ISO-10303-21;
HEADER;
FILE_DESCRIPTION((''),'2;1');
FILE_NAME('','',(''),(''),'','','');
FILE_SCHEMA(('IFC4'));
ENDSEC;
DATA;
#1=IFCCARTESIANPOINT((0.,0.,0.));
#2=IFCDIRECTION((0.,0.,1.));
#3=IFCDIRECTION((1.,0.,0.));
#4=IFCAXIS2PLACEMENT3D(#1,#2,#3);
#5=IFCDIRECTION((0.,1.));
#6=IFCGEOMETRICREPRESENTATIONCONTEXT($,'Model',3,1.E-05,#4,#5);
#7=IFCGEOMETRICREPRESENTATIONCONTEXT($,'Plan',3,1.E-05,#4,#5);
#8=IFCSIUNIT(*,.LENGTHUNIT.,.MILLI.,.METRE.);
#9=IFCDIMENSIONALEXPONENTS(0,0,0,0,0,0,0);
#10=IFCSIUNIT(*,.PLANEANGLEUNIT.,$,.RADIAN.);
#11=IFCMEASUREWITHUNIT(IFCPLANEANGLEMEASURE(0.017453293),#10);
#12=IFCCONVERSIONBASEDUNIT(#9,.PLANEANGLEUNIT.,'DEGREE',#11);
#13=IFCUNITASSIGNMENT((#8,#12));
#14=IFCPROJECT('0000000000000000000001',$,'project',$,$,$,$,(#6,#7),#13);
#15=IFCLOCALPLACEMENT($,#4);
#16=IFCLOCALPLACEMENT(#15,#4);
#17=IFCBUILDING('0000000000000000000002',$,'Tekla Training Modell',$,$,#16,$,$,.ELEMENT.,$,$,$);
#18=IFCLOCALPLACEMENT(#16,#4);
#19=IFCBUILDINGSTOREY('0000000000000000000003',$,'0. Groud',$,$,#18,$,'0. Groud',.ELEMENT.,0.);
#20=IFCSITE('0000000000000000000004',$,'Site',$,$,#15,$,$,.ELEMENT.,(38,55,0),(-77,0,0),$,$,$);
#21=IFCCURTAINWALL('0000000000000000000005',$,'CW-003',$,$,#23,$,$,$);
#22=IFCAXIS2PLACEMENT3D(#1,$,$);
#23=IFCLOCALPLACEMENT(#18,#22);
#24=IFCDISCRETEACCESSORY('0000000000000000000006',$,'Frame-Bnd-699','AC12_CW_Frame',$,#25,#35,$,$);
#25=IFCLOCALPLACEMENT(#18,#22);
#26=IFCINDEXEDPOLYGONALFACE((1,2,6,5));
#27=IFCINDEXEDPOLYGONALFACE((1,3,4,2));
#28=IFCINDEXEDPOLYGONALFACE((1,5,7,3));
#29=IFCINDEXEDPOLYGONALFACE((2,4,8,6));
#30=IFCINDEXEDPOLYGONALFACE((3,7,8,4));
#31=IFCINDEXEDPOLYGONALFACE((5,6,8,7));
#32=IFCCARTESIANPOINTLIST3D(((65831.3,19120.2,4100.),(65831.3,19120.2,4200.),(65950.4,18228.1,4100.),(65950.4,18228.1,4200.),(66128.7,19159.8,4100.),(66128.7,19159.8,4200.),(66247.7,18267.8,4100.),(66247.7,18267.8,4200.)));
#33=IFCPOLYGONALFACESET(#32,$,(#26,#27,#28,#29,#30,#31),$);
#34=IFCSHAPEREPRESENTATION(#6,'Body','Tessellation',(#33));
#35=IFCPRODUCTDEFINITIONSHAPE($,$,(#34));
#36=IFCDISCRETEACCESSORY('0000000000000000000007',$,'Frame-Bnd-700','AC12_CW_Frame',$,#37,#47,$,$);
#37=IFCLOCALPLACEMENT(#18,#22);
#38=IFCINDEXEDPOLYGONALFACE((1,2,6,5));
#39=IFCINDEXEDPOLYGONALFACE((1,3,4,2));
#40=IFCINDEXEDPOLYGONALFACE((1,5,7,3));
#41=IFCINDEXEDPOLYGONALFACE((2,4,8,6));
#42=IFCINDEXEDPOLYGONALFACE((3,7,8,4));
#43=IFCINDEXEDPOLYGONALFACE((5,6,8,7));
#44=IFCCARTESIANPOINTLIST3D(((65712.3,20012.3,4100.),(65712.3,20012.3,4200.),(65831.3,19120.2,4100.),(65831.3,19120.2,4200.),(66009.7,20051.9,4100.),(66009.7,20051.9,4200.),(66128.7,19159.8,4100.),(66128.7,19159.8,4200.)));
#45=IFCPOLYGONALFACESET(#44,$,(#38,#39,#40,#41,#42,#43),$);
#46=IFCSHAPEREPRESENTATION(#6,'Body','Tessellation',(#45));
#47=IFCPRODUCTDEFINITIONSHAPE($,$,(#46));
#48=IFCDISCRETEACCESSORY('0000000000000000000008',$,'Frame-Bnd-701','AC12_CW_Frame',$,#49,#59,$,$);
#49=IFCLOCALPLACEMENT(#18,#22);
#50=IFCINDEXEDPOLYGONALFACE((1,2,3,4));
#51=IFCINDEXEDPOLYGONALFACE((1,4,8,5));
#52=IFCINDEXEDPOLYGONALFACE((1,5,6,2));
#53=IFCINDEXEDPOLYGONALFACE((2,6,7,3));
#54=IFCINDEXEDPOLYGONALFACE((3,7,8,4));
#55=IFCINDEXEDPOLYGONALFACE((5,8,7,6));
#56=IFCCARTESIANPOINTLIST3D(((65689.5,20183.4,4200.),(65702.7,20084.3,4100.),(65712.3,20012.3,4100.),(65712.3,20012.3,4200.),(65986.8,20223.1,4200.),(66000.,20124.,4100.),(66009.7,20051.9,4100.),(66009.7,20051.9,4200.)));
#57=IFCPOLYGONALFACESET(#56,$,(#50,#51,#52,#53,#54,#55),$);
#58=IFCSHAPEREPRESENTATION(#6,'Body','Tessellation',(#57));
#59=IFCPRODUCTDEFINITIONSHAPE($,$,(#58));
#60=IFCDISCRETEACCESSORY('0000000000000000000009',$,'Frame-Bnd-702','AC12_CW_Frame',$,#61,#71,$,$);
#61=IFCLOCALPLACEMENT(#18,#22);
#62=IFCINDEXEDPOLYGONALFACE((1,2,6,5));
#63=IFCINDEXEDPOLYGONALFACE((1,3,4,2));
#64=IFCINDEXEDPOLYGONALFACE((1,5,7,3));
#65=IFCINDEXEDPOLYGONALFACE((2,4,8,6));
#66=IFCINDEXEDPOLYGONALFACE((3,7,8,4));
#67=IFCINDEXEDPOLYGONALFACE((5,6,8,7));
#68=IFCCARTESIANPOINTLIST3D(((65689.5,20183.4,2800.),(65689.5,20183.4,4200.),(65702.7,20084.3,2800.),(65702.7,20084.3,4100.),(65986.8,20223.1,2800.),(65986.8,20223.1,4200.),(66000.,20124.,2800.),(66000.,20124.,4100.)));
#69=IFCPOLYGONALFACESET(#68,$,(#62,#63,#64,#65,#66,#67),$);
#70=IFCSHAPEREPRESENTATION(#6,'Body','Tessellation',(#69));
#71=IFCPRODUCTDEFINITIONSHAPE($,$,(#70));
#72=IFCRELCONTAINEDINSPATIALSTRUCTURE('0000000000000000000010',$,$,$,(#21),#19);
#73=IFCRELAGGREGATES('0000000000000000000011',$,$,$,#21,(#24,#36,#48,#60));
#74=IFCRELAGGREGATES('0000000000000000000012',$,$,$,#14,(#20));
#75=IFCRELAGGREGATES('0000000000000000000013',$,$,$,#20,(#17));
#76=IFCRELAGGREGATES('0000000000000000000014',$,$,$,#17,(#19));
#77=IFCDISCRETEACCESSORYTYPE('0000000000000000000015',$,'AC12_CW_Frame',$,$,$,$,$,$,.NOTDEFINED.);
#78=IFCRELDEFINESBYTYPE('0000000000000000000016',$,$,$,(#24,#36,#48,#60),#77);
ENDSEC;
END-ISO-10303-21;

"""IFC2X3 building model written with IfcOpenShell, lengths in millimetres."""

from ifc_helpers import new_model, entity, si_unit, converted_unit, direction, frame, origin_with_axes, place, context, project, spatial, polyline, outline, extrude, source, transform, mapped, type_object, element, aggregate, save


model = new_model("IFC2X3")

# Units and contexts
model_context = context("Model", 3, precision=1e-05, world=origin_with_axes(), true_north=direction((0.0, 1.0)))
plan_context = context("Plan", 3, precision=1e-05, world=origin_with_axes(), true_north=direction((0.0, 1.0)))
ifc_project = project(units=[si_unit("LENGTHUNIT", "METRE", prefix="MILLI"), converted_unit("PLANEANGLEUNIT", "DEGREE", entity("IfcPlaneAngleMeasure", 0.017453293), si_unit("PLANEANGLEUNIT", "RADIAN"), dimensions=[0, 0, 0, 0, 0, 0, 0])], contexts=[model_context, plan_context])

# Site, building, storey
site_placement = place(None, origin_with_axes())
site = spatial("IfcSite", under=ifc_project, at=site_placement, Name="Site", CompositionType="ELEMENT", RefLatitude=(38, 55, 0), RefLongitude=(-77, 0, 0))
building_placement = place(site_placement, origin_with_axes())
building = spatial("IfcBuilding", under=site, at=building_placement, Name="Tekla Training Modell", CompositionType="ELEMENT")
storey_placement = place(building_placement, origin_with_axes())
storey = spatial("IfcBuildingStorey", under=building, at=storey_placement, Name="0. Groud", LongName="0. Groud", CompositionType="ELEMENT", Elevation=0.0)

# Curtain wall
curtain_wall_placement = place(storey_placement, frame((68221.7, 3095.5, 0.0), z_axis=(0.0, 0.0, 1.0), x_axis=(-0.132257, 0.991216, 0.0)))
curtain_wall = element("IfcCurtainWall", 1, at=curtain_wall_placement, inside=storey, Name="CW-003")

# Discrete accessories
discrete_accessory_type = type_object("IfcDiscreteAccessoryType", Name="AC12_CW_Frame")
shared_shape_1 = source(origin_with_axes(), model_context, "Body", "SweptSolid", [
    extrude(outline(polyline([(0.0, 0.0), (300.0, 0.0), (300.0, -900.0), (0.0, -900.0), (0.0, 0.0)])), origin_with_axes(), (0.0, 0.0, 1.0), 100.0),
])
discrete_accessory_1_placement = place(storey_placement, frame((65831.3, 19120.2, 4100.0), z_axis=(0.0, 0.0, 1.0), x_axis=(0.991216, 0.132257, 0.0)))
discrete_accessory_1 = element("IfcDiscreteAccessory", 2, at=discrete_accessory_1_placement, type_object=discrete_accessory_type, Name="Frame-Bnd-699", Description="AC12_CW_Frame", context=model_context, shape_type="MappedRepresentation", body=[
    mapped(shared_shape_1, transform((0.0, 0.0, 0.0), scale=1.0)),
])
discrete_accessory_2_placement = place(storey_placement, frame((65712.3, 20012.3, 4100.0), z_axis=(0.0, 0.0, 1.0), x_axis=(0.991216, 0.132257, 0.0)))
discrete_accessory_2 = element("IfcDiscreteAccessory", 3, at=discrete_accessory_2_placement, type_object=discrete_accessory_type, Name="Frame-Bnd-700", Description="AC12_CW_Frame", context=model_context, shape_type="MappedRepresentation", body=[
    mapped(shared_shape_1, transform((0.0, 0.0, 0.0), scale=1.0)),
])
shared_shape_2 = source(origin_with_axes(), model_context, "Body", "SweptSolid", [
    extrude(outline(polyline([(0.0, 0.0), (141.4, 0.0), (19.3, -122.1), (-51.4, -51.4), (0.0, 0.0)])), origin_with_axes(), (0.0, 0.0, 1.0), 300.0),
])
discrete_accessory_3_placement = place(storey_placement, frame((66000.0, 20124.0, 4100.0), z_axis=(-0.991216, -0.132257, 0.0), x_axis=(-0.09352, 0.700895, 0.707107)))
discrete_accessory_3 = element("IfcDiscreteAccessory", 4, at=discrete_accessory_3_placement, type_object=discrete_accessory_type, Name="Frame-Bnd-701", Description="AC12_CW_Frame", context=model_context, shape_type="MappedRepresentation", body=[
    mapped(shared_shape_2, transform((0.0, 0.0, 0.0), scale=1.0)),
])
shared_shape_3 = source(origin_with_axes(), model_context, "Body", "SweptSolid", [
    extrude(outline(polyline([(0.0, 0.0), (100.0, 0.0), (100.0, -1400.0), (0.0, -1300.0), (0.0, 0.0)])), origin_with_axes(), (0.0, 0.0, 1.0), 300.0),
])
discrete_accessory_4_placement = place(storey_placement, frame((66000.0, 20124.0, 2800.0), z_axis=(-0.991216, -0.132257, 0.0), x_axis=(-0.132257, 0.991216, 0.0)))
discrete_accessory_4 = element("IfcDiscreteAccessory", 5, at=discrete_accessory_4_placement, type_object=discrete_accessory_type, Name="Frame-Bnd-702", Description="AC12_CW_Frame", context=model_context, shape_type="MappedRepresentation", body=[
    mapped(shared_shape_3, transform((0.0, 0.0, 0.0), scale=1.0)),
])
aggregate(curtain_wall, [discrete_accessory_1, discrete_accessory_2, discrete_accessory_3, discrete_accessory_4])

save(model, "model.ifc")
